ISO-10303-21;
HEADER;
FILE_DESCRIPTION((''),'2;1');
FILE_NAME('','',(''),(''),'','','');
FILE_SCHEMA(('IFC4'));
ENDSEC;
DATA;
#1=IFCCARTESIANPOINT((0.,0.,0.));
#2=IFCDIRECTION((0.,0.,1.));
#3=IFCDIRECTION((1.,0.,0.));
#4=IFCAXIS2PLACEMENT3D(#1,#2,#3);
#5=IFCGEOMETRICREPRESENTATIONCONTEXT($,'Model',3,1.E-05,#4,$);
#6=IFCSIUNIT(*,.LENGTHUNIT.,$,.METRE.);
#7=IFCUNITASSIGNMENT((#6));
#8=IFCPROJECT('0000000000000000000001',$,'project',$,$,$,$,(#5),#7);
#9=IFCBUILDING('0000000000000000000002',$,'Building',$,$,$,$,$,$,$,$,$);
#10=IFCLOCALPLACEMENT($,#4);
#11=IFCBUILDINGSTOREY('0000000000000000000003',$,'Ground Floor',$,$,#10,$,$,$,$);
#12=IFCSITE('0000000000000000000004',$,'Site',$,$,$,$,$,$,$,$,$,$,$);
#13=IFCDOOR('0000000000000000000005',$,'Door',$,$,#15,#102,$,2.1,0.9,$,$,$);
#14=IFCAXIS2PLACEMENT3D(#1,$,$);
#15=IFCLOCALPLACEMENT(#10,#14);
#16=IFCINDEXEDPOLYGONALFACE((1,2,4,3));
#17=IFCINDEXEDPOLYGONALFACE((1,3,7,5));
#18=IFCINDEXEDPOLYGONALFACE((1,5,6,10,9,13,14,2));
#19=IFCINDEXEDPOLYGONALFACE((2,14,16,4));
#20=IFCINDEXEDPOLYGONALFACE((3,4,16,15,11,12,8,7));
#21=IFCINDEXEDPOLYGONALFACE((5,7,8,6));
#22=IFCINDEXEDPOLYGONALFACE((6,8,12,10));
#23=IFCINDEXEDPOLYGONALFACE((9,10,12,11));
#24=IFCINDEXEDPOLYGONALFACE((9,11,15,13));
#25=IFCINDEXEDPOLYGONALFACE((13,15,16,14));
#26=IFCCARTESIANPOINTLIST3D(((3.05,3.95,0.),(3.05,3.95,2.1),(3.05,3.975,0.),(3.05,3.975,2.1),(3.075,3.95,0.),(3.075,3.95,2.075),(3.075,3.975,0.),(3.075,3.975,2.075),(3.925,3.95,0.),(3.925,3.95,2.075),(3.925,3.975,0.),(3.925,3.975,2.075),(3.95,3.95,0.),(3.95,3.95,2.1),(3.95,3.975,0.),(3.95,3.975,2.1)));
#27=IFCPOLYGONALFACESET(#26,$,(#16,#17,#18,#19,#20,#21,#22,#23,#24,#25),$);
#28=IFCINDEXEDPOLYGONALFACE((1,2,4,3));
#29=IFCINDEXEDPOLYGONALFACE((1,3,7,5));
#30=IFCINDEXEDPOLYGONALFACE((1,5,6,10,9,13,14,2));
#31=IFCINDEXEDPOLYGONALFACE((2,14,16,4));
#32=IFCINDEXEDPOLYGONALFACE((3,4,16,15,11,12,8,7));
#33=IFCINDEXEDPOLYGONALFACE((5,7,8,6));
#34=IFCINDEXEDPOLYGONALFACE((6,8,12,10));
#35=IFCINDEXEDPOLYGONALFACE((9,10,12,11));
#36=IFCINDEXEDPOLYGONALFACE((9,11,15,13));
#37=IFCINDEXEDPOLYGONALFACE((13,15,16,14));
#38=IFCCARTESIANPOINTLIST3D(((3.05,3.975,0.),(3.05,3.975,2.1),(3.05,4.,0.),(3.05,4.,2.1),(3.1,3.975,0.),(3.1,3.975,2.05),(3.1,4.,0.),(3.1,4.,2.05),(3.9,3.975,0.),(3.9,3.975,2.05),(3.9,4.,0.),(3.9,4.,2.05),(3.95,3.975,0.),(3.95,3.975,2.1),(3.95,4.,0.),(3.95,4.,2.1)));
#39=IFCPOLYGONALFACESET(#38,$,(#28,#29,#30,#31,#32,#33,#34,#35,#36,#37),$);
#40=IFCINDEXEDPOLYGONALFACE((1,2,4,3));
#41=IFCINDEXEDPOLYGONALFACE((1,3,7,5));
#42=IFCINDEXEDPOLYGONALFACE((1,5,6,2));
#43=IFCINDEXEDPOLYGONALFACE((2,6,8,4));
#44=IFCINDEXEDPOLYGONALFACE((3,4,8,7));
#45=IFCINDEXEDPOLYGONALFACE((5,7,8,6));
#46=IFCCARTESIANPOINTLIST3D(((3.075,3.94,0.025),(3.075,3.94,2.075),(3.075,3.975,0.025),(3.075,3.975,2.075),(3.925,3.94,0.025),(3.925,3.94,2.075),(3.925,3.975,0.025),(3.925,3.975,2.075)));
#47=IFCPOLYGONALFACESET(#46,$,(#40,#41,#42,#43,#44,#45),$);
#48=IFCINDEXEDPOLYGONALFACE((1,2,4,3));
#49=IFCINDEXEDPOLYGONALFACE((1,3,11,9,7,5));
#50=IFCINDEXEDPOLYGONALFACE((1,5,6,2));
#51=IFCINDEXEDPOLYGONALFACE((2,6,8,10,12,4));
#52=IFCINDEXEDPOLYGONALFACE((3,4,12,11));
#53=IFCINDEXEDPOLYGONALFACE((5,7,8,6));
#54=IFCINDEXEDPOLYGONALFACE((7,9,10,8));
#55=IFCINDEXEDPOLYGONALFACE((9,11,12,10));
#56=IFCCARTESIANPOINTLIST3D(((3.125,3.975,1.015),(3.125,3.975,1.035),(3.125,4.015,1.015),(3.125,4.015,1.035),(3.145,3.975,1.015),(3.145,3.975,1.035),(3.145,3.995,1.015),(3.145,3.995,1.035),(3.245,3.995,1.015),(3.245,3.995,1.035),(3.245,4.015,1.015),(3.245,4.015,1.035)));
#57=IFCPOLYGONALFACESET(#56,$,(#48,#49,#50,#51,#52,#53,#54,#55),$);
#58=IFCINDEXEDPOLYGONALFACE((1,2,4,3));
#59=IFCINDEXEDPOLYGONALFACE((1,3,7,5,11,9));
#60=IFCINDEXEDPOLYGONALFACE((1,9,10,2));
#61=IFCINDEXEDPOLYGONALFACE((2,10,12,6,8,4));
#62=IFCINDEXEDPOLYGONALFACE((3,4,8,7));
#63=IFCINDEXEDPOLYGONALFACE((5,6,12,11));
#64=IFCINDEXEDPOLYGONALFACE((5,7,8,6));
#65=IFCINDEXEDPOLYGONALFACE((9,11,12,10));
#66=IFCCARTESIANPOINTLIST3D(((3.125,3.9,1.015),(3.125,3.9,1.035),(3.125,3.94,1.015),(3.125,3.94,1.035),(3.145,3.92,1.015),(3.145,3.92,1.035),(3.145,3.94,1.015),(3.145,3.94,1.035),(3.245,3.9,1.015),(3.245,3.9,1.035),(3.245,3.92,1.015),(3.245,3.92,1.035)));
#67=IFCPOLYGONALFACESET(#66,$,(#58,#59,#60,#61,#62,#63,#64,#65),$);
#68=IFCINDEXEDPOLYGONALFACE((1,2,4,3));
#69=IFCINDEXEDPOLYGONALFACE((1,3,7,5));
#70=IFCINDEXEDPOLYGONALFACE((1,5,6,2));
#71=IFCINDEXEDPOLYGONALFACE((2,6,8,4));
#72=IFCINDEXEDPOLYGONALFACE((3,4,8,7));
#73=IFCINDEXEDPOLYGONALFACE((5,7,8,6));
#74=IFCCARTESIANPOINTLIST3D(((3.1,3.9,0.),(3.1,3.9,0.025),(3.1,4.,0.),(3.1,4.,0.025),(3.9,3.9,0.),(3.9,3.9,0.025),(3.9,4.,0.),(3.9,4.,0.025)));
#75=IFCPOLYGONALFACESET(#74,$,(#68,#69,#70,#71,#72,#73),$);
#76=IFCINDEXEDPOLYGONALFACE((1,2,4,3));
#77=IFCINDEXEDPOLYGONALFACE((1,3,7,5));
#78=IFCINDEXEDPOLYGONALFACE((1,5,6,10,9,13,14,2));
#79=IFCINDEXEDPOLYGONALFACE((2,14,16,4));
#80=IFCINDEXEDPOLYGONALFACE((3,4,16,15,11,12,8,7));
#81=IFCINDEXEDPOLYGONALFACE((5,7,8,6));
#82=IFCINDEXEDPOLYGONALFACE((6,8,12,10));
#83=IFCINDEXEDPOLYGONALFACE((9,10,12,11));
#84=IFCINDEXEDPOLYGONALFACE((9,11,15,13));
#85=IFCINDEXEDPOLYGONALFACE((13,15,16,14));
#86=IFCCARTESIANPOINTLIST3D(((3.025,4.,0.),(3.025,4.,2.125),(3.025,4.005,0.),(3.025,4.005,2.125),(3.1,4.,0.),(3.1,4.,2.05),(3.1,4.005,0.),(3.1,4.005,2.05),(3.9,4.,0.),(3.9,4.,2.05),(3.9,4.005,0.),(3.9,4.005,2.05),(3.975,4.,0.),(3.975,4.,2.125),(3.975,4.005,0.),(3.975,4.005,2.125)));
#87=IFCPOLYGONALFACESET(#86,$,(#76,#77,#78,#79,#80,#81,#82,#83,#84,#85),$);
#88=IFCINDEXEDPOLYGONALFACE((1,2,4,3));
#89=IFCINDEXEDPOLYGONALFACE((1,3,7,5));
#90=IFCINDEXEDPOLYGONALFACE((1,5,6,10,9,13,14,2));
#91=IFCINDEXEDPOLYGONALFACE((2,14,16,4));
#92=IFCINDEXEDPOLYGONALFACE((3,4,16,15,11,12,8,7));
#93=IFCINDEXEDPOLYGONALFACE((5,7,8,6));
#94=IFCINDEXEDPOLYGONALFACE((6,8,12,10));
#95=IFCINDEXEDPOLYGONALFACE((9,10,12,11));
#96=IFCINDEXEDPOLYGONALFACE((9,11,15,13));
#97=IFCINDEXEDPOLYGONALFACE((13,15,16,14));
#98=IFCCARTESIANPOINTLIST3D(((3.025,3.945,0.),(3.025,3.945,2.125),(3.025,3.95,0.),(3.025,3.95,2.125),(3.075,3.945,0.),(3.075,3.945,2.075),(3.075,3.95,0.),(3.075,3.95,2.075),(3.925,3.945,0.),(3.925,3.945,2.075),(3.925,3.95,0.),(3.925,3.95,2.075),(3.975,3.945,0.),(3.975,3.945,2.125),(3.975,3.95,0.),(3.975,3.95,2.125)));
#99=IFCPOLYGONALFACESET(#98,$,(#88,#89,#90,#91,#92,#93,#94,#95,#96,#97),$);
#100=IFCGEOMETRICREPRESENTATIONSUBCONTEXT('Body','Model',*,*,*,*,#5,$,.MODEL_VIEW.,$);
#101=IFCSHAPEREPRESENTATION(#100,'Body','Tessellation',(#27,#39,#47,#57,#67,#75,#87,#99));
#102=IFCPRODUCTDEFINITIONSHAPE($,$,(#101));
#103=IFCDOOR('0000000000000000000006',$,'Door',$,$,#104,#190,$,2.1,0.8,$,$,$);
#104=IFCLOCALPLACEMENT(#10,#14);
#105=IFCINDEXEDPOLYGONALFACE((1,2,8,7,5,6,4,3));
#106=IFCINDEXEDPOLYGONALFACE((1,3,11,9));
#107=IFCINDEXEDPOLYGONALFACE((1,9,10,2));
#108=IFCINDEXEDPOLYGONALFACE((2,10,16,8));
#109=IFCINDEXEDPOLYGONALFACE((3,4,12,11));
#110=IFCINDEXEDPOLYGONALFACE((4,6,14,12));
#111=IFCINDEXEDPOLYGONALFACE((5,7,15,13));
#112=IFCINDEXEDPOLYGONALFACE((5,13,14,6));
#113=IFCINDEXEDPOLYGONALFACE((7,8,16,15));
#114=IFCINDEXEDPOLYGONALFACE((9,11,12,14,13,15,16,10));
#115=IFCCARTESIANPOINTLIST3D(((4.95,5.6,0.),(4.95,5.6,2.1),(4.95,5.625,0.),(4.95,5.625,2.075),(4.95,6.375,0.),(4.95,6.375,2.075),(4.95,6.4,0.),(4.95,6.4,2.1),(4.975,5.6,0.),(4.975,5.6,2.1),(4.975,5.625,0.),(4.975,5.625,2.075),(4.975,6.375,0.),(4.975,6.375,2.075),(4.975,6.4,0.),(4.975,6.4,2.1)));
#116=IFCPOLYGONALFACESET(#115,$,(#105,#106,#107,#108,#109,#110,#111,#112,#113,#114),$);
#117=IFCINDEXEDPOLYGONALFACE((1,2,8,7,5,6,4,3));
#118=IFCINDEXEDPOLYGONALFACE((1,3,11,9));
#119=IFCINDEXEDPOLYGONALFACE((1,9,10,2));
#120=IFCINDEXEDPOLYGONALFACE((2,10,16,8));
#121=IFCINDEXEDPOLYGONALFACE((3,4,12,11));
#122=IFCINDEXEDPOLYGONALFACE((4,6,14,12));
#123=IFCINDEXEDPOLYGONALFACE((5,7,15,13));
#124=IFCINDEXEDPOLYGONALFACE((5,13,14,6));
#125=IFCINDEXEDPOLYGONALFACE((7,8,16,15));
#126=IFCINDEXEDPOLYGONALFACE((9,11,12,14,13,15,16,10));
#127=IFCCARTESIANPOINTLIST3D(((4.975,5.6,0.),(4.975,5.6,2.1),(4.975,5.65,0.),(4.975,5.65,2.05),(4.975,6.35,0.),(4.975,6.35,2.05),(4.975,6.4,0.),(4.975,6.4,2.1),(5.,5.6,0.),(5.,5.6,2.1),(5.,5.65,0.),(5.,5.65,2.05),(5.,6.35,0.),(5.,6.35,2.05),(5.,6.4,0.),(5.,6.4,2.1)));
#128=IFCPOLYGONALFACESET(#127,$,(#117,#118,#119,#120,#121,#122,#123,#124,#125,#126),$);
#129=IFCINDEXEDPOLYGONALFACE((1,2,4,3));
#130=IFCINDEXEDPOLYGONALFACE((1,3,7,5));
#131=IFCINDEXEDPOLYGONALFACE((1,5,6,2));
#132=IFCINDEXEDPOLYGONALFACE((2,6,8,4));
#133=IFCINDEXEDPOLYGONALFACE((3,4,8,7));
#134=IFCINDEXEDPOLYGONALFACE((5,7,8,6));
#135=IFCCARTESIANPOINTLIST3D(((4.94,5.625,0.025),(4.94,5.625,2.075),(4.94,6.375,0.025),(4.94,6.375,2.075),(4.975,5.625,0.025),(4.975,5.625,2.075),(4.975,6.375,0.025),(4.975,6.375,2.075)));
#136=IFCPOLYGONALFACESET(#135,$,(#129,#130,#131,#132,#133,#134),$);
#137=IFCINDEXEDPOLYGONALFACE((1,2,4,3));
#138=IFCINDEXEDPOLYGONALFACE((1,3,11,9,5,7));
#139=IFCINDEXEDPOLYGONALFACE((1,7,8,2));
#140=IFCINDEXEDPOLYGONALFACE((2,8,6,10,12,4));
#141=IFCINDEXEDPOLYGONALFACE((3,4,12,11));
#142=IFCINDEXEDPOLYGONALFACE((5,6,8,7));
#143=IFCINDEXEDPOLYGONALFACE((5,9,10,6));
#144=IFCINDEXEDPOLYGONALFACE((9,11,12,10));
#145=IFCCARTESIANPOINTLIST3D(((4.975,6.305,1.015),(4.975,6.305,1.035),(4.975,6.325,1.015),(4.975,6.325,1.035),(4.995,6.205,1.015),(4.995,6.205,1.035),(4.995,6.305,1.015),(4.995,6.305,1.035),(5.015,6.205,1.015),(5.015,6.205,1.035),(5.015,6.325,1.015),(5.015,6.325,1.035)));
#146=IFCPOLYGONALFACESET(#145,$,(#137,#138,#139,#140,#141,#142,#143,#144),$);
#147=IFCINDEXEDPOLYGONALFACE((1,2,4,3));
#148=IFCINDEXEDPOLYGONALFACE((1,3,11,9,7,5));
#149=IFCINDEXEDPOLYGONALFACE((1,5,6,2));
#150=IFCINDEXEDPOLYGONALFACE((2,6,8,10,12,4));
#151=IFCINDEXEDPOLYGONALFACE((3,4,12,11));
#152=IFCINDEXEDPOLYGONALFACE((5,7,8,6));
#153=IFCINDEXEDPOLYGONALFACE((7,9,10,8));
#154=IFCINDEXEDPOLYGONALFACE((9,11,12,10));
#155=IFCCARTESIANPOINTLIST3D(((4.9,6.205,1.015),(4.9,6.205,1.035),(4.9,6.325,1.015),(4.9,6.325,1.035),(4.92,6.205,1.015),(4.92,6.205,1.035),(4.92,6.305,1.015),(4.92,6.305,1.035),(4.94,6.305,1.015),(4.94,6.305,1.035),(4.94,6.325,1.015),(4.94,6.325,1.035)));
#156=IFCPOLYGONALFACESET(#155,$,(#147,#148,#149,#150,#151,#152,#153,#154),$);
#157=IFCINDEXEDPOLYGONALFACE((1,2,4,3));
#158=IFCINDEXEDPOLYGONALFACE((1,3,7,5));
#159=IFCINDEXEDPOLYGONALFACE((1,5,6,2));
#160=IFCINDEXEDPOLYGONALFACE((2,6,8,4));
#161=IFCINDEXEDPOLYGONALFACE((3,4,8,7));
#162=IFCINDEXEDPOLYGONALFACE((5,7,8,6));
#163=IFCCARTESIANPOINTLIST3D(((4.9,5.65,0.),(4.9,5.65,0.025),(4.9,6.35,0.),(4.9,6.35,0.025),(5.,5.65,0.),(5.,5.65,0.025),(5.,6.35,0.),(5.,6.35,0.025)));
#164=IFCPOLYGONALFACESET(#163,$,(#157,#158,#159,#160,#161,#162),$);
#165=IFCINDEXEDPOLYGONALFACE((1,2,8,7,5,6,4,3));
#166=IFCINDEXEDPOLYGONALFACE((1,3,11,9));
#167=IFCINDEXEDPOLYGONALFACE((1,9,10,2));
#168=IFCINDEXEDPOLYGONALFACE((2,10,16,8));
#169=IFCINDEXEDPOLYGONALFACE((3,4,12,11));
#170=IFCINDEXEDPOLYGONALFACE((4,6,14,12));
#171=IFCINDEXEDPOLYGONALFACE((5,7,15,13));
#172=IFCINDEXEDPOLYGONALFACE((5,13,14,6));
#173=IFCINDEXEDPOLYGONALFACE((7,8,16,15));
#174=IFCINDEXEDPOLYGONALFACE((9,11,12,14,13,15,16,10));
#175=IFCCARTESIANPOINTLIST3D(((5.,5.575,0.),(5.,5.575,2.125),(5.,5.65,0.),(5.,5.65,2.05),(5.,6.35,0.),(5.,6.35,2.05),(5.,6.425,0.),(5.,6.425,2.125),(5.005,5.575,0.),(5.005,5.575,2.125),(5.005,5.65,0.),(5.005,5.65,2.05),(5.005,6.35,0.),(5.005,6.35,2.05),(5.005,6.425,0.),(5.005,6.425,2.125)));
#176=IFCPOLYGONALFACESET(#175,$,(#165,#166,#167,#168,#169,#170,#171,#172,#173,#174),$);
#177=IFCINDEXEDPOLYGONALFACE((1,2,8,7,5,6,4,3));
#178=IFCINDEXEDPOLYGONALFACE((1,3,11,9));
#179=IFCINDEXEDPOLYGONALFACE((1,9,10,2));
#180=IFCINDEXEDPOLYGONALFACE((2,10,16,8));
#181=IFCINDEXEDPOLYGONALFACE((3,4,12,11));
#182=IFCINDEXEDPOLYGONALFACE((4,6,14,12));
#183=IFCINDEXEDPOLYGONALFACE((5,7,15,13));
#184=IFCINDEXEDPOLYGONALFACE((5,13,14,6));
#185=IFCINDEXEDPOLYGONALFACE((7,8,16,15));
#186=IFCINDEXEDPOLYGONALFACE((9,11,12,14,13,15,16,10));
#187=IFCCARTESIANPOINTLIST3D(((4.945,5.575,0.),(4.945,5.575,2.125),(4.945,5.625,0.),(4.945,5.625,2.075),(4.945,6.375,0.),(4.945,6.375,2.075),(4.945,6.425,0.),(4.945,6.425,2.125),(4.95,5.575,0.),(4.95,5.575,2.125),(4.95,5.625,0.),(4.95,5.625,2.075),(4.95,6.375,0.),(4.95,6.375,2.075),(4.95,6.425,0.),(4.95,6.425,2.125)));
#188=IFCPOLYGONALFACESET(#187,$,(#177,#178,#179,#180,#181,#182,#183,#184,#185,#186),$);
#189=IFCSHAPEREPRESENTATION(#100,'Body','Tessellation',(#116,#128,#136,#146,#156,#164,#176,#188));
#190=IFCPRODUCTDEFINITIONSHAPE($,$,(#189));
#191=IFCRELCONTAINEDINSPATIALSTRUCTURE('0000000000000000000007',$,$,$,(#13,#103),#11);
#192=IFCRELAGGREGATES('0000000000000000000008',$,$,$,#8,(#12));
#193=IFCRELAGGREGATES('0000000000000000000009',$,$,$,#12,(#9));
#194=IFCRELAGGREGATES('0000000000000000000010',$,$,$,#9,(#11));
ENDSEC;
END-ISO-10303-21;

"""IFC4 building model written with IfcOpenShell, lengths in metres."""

from ifc_helpers import new_model, si_unit, frame, origin_with_axes, place, context, subcontext, project, spatial, line, indexed_curve, outline, extrude, element, save


model = new_model("IFC4")

# Units and contexts
model_context = context("Model", 3, precision=1e-05, world=origin_with_axes())
body_context = subcontext(model_context, "Body", "Model", "MODEL_VIEW")
ifc_project = project(units=[si_unit("LENGTHUNIT", "METRE")], contexts=[model_context])

# Site, building, storey
site = spatial("IfcSite", under=ifc_project, Name="Site")
building = spatial("IfcBuilding", under=site, Name="Building")
storey_placement = place(None, origin_with_axes())
storey = spatial("IfcBuildingStorey", under=building, at=storey_placement, Name="Ground Floor")

# Doors
door_1_placement = place(storey_placement, frame((3.95, 4.0, 0.0), z_axis=(0.0, 0.0, 1.0), x_axis=(-1.0, 0.0, 0.0)))
element("IfcDoor", 1, at=door_1_placement, inside=storey, Name="Door", OverallHeight=2.1, OverallWidth=0.9, context=body_context, shape_type="SweptSolid", body=[
    extrude(outline(indexed_curve([(0.0, 0.0), (0.0, 2.1), (0.9, 2.1), (0.9, 0.0), (0.875, 0.0), (0.875, 2.075), (0.025, 2.075), (0.025, 0.0)], segments=[line(1, 2, 3, 4, 5, 6, 7, 8, 1)])), frame((0.0, 0.025, 0.0), z_axis=(0.0, -1.0, 0.0), x_axis=(1.0, 0.0, 0.0)), (0.0, 0.0, -1.0), 0.025),
    extrude(outline(indexed_curve([(0.0, 0.0), (0.0, 2.1), (0.9, 2.1), (0.9, 0.0), (0.85, 0.0), (0.85, 2.05), (0.05, 2.05), (0.05, 0.0)], segments=[line(1, 2, 3, 4, 5, 6, 7, 8, 1)])), frame((0.0, 0.0, 0.0), z_axis=(0.0, -1.0, 0.0), x_axis=(1.0, 0.0, 0.0)), (0.0, 0.0, -1.0), 0.025),
    extrude(outline(indexed_curve([(0.0, 0.0), (0.85, 0.0), (0.85, 0.035), (0.0, 0.035)], segments=[line(1, 2, 3, 4, 1)])), frame((0.025, 0.025, 0.025), z_axis=(0.0, 0.0, 1.0), x_axis=(1.0, 0.0, 0.0)), (0.0, 0.0, 1.0), 2.05),
    extrude(outline(indexed_curve([(0.0, 0.0), (0.0, -0.04), (-0.12, -0.04), (-0.12, -0.02), (-0.02, -0.02), (-0.02, 0.0)], segments=[line(1, 2, 3, 4, 5, 6, 1)])), frame((0.825, 0.025, 1.015), z_axis=(0.0, 0.0, 1.0), x_axis=(1.0, 0.0, 0.0)), (0.0, 0.0, 1.0), 0.02),
    extrude(outline(indexed_curve([(0.0, 0.0), (0.0, 0.04), (-0.12, 0.04), (-0.12, 0.02), (-0.02, 0.02), (-0.02, 0.0)], segments=[line(1, 2, 3, 4, 5, 6, 1)])), frame((0.825, 0.06, 1.015), z_axis=(0.0, 0.0, 1.0), x_axis=(1.0, 0.0, 0.0)), (0.0, 0.0, 1.0), 0.02),
    extrude(outline(indexed_curve([(0.0, 0.0), (0.8, 0.0), (0.8, 0.1), (0.0, 0.1)], segments=[line(1, 2, 3, 4, 1)])), frame((0.05, 0.0, 0.0), z_axis=(0.0, 0.0, 1.0), x_axis=(1.0, 0.0, 0.0)), (0.0, 0.0, 1.0), 0.025),
    extrude(outline(indexed_curve([(0.0, 0.0), (0.0, 2.125), (0.95, 2.125), (0.95, 0.0), (0.875, 0.0), (0.875, 2.05), (0.075, 2.05), (0.075, 0.0)], segments=[line(1, 2, 3, 4, 5, 6, 7, 8, 1)])), frame((-0.025, -0.005, 0.0), z_axis=(0.0, -1.0, 0.0), x_axis=(1.0, 0.0, 0.0)), (0.0, 0.0, -1.0), 0.005),
    extrude(outline(indexed_curve([(0.0, 0.0), (0.0, 2.125), (0.95, 2.125), (0.95, 0.0), (0.9, 0.0), (0.9, 2.075), (0.05, 2.075), (0.05, 0.0)], segments=[line(1, 2, 3, 4, 5, 6, 7, 8, 1)])), frame((-0.025, 0.05, 0.0), z_axis=(0.0, -1.0, 0.0), x_axis=(1.0, 0.0, 0.0)), (0.0, 0.0, -1.0), 0.005),
])
door_2_placement = place(storey_placement, frame((5.0, 5.6, 0.0), z_axis=(0.0, 0.0, 1.0), x_axis=(0.0, 1.0, 0.0)))
element("IfcDoor", 2, at=door_2_placement, inside=storey, Name="Door", OverallHeight=2.1, OverallWidth=0.8, context=body_context, shape_type="SweptSolid", body=[
    extrude(outline(indexed_curve([(0.0, 0.0), (0.0, 2.1), (0.8, 2.1), (0.8, 0.0), (0.775, 0.0), (0.775, 2.075), (0.025, 2.075), (0.025, 0.0)], segments=[line(1, 2, 3, 4, 5, 6, 7, 8, 1)])), frame((0.0, 0.025, 0.0), z_axis=(0.0, -1.0, 0.0), x_axis=(1.0, 0.0, 0.0)), (0.0, 0.0, -1.0), 0.025),
    extrude(outline(indexed_curve([(0.0, 0.0), (0.0, 2.1), (0.8, 2.1), (0.8, 0.0), (0.75, 0.0), (0.75, 2.05), (0.05, 2.05), (0.05, 0.0)], segments=[line(1, 2, 3, 4, 5, 6, 7, 8, 1)])), frame((0.0, 0.0, 0.0), z_axis=(0.0, -1.0, 0.0), x_axis=(1.0, 0.0, 0.0)), (0.0, 0.0, -1.0), 0.025),
    extrude(outline(indexed_curve([(0.0, 0.0), (0.75, 0.0), (0.75, 0.035), (0.0, 0.035)], segments=[line(1, 2, 3, 4, 1)])), frame((0.025, 0.025, 0.025), z_axis=(0.0, 0.0, 1.0), x_axis=(1.0, 0.0, 0.0)), (0.0, 0.0, 1.0), 2.05),
    extrude(outline(indexed_curve([(0.0, 0.0), (0.0, -0.04), (-0.12, -0.04), (-0.12, -0.02), (-0.02, -0.02), (-0.02, 0.0)], segments=[line(1, 2, 3, 4, 5, 6, 1)])), frame((0.725, 0.025, 1.015), z_axis=(0.0, 0.0, 1.0), x_axis=(1.0, 0.0, 0.0)), (0.0, 0.0, 1.0), 0.02),
    extrude(outline(indexed_curve([(0.0, 0.0), (0.0, 0.04), (-0.12, 0.04), (-0.12, 0.02), (-0.02, 0.02), (-0.02, 0.0)], segments=[line(1, 2, 3, 4, 5, 6, 1)])), frame((0.725, 0.06, 1.015), z_axis=(0.0, 0.0, 1.0), x_axis=(1.0, 0.0, 0.0)), (0.0, 0.0, 1.0), 0.02),
    extrude(outline(indexed_curve([(0.0, 0.0), (0.7, 0.0), (0.7, 0.1), (0.0, 0.1)], segments=[line(1, 2, 3, 4, 1)])), frame((0.05, 0.0, 0.0), z_axis=(0.0, 0.0, 1.0), x_axis=(1.0, 0.0, 0.0)), (0.0, 0.0, 1.0), 0.025),
    extrude(outline(indexed_curve([(0.0, 0.0), (0.0, 2.125), (0.85, 2.125), (0.85, 0.0), (0.775, 0.0), (0.775, 2.05), (0.075, 2.05), (0.075, 0.0)], segments=[line(1, 2, 3, 4, 5, 6, 7, 8, 1)])), frame((-0.025, -0.005, 0.0), z_axis=(0.0, -1.0, 0.0), x_axis=(1.0, 0.0, 0.0)), (0.0, 0.0, -1.0), 0.005),
    extrude(outline(indexed_curve([(0.0, 0.0), (0.0, 2.125), (0.85, 2.125), (0.85, 0.0), (0.8, 0.0), (0.8, 2.075), (0.05, 2.075), (0.05, 0.0)], segments=[line(1, 2, 3, 4, 5, 6, 7, 8, 1)])), frame((-0.025, 0.05, 0.0), z_axis=(0.0, -1.0, 0.0), x_axis=(1.0, 0.0, 0.0)), (0.0, 0.0, -1.0), 0.005),
])

save(model, "model.ifc")
